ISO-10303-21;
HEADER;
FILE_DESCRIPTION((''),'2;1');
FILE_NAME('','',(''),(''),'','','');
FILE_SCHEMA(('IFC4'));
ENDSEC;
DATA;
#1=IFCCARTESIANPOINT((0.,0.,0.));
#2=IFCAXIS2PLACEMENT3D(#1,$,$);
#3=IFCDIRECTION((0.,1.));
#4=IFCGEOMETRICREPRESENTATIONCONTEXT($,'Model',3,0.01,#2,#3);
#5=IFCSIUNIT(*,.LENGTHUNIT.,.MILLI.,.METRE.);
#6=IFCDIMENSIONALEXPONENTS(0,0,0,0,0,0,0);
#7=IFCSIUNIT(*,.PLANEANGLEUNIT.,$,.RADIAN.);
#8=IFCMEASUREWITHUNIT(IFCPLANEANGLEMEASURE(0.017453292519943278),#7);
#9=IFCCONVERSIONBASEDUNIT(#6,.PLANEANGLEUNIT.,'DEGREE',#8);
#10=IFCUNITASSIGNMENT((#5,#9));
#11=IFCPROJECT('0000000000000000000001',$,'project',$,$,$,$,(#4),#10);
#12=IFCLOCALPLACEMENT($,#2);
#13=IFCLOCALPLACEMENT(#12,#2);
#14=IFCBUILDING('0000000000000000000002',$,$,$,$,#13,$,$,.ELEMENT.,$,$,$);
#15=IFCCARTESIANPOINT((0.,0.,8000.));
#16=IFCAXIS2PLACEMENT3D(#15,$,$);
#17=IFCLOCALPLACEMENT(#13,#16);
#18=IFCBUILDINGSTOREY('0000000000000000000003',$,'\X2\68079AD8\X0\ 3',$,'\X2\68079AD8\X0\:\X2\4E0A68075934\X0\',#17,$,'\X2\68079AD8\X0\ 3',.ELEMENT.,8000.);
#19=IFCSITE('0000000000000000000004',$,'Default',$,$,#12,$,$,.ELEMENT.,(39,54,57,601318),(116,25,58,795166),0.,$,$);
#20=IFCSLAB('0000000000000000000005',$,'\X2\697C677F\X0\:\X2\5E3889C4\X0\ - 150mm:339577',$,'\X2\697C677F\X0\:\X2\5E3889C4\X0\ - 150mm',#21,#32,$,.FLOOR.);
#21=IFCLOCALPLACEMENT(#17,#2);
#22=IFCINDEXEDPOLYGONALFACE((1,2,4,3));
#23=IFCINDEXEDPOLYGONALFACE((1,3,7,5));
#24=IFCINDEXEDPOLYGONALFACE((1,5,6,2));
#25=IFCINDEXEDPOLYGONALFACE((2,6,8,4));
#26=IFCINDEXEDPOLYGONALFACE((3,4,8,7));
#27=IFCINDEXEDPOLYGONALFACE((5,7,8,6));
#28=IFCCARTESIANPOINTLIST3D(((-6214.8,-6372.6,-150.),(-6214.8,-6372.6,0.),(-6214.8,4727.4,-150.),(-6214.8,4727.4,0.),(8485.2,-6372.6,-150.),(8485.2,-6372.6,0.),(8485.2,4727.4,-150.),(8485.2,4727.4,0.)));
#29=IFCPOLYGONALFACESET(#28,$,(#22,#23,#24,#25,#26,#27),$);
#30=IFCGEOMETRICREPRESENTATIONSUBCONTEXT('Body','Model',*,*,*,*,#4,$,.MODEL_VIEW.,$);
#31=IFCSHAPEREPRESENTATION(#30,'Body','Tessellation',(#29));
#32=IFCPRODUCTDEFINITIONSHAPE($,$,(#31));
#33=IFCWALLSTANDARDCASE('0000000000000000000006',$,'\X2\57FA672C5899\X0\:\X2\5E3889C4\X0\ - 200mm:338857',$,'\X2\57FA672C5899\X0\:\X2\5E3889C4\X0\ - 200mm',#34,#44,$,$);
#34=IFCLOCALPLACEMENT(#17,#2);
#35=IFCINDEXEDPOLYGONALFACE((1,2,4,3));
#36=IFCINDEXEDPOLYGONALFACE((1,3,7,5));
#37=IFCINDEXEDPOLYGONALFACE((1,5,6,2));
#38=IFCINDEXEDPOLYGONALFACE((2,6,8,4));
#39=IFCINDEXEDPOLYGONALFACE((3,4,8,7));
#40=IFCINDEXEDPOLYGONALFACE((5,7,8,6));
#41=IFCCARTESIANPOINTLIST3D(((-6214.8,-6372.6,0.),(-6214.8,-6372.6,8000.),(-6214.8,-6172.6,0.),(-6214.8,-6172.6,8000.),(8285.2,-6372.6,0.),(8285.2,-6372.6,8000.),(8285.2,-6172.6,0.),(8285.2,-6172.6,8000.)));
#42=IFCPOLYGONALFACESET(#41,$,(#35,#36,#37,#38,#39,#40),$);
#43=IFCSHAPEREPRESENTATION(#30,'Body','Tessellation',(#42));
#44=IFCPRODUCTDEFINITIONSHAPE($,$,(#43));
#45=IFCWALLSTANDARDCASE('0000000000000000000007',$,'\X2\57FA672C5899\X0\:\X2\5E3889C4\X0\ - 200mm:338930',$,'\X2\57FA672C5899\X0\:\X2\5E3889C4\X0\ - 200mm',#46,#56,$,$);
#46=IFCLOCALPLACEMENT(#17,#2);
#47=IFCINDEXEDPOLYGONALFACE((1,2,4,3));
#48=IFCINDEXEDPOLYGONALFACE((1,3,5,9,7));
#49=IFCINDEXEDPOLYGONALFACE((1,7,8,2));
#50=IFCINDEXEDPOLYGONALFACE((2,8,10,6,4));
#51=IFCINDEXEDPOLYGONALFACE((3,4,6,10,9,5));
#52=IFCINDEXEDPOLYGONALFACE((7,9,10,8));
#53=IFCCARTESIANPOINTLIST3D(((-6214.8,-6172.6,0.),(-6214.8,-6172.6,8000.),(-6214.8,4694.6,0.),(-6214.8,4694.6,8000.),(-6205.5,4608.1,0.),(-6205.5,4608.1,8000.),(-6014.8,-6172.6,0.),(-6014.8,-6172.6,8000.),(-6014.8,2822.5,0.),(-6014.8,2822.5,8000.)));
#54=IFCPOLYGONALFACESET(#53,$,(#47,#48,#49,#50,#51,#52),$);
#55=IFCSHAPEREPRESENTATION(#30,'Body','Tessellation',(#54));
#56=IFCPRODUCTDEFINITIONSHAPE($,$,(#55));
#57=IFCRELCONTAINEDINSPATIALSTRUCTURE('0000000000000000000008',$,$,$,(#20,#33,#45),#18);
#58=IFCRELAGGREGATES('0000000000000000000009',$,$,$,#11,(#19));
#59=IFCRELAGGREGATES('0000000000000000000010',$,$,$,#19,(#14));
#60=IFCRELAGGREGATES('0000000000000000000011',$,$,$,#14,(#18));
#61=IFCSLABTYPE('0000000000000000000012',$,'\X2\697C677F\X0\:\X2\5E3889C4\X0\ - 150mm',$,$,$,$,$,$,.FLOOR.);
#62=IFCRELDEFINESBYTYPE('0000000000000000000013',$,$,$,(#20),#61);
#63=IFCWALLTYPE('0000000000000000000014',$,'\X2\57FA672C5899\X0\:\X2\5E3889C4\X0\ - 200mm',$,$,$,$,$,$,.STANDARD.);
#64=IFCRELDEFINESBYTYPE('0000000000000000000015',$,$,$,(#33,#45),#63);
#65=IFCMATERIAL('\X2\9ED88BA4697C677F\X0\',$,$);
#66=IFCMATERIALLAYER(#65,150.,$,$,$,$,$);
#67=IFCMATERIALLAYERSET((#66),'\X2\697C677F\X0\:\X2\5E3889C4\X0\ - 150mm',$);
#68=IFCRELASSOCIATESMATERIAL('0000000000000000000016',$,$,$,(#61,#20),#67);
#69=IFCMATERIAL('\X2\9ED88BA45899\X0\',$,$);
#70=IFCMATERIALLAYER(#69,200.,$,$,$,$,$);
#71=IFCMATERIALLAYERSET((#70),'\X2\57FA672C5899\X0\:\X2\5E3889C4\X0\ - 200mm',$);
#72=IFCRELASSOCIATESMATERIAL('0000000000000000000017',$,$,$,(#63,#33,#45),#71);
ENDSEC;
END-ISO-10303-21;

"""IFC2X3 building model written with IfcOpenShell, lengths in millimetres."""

from ifc_helpers import new_model, entity, si_unit, converted_unit, direction, frame, frame_2d, origin, origin_2d_with_axis, place, context, subcontext, project, spatial, polyline, rectangle, outline, extrude, material, layer, layer_set, layer_usage, type_object, element, save


model = new_model("IFC2X3")

# Units and contexts
model_context = context("Model", 3, precision=0.01, world=origin(), true_north=direction((0.0, 1.0)))
body_context = subcontext(model_context, "Body", "Model", "MODEL_VIEW")
ifc_project = project(units=[si_unit("LENGTHUNIT", "METRE", prefix="MILLI"), converted_unit("PLANEANGLEUNIT", "DEGREE", entity("IfcPlaneAngleMeasure", 0.017453292519943278), si_unit("PLANEANGLEUNIT", "RADIAN"), dimensions=[0, 0, 0, 0, 0, 0, 0])], contexts=[model_context])

# Site, building, storey
site_placement = place(None, origin())
site = spatial("IfcSite", under=ifc_project, at=site_placement, Name="Default", CompositionType="ELEMENT", RefLatitude=(39, 54, 57, 601318), RefLongitude=(116, 25, 58, 795166), RefElevation=0.0)
building_placement = place(site_placement, origin())
building = spatial("IfcBuilding", under=site, at=building_placement, CompositionType="ELEMENT")
storey_placement = place(building_placement, frame((0.0, 0.0, 8000.0)))
storey = spatial("IfcBuildingStorey", under=building, at=storey_placement, Name="标高 3", ObjectType="标高:上标头", LongName="标高 3", CompositionType="ELEMENT", Elevation=8000.0)

# Slab
ifc_material_1 = material(Name="默认楼板")
ifc_layer_1 = layer(ifc_material_1, 150.0)
ifc_layer_set_1 = layer_set([ifc_layer_1], Name="楼板:常规 - 150mm")
ifc_layer_usage_1 = layer_usage(ifc_layer_set_1, "AXIS3", "POSITIVE", 0.0)
slab_type = type_object("IfcSlabType", Name="楼板:常规 - 150mm", PredefinedType="FLOOR", material=ifc_layer_set_1)
slab_placement = place(storey_placement, origin())
element("IfcSlab", 1, at=slab_placement, inside=storey, type_object=slab_type, material=ifc_layer_usage_1, Name="楼板:常规 - 150mm:339577", ObjectType="楼板:常规 - 150mm", PredefinedType="FLOOR", context=body_context, shape_type="SweptSolid", body=[
    extrude(rectangle(XDim=11100.0, YDim=14700.0, at=origin_2d_with_axis()), frame((1135.2, -822.6, 0.0), z_axis=(0.0, 0.0, -1.0), x_axis=(0.0, 1.0, 0.0)), (0.0, 0.0, 1.0), 150.0),
])

# Walls
ifc_material_2 = material(Name="默认墙")
ifc_layer_2 = layer(ifc_material_2, 200.0)
ifc_layer_set_2 = layer_set([ifc_layer_2], Name="基本墙:常规 - 200mm")
wall_type = type_object("IfcWallType", Name="基本墙:常规 - 200mm", PredefinedType="STANDARD", material=ifc_layer_set_2)
ifc_layer_usage_2 = layer_usage(ifc_layer_set_2, "AXIS2", "NEGATIVE", 100.0)
wall_1_placement = place(storey_placement, frame((8285.2, -6272.6, 0.0), z_axis=(0.0, 0.0, 1.0), x_axis=(-1.0, 0.0, 0.0)))
element("IfcWallStandardCase", 2, at=wall_1_placement, inside=storey, type_object=wall_type, material=ifc_layer_usage_2, Name="基本墙:常规 - 200mm:338857", ObjectType="基本墙:常规 - 200mm", context=body_context, shape_type="SweptSolid", body=[
    extrude(rectangle(XDim=14500.0, YDim=200.0, at=frame_2d((7250.0, 0.0), x_axis=(-1.0, 0.0))), origin(), (0.0, 0.0, 1.0), 8000.0),
])
ifc_layer_usage_3 = layer_usage(ifc_layer_set_2, "AXIS2", "NEGATIVE", 100.0)
wall_2_placement = place(storey_placement, frame((-6114.8, -6172.6, 0.0), z_axis=(0.0, 0.0, 1.0), x_axis=(0.0, 1.0, 0.0)))
element("IfcWallStandardCase", 3, at=wall_2_placement, inside=storey, type_object=wall_type, material=ifc_layer_usage_3, Name="基本墙:常规 - 200mm:338930", ObjectType="基本墙:常规 - 200mm", context=body_context, shape_type="SweptSolid", body=[
    extrude(outline(polyline([(8995.0, -100.0), (10780.7, 90.8), (10867.2, 100.0), (0.0, 100.0), (0.0, -100.0), (8995.0, -100.0)])), origin(), (0.0, 0.0, 1.0), 8000.0),
])

save(model, "model.ifc")
